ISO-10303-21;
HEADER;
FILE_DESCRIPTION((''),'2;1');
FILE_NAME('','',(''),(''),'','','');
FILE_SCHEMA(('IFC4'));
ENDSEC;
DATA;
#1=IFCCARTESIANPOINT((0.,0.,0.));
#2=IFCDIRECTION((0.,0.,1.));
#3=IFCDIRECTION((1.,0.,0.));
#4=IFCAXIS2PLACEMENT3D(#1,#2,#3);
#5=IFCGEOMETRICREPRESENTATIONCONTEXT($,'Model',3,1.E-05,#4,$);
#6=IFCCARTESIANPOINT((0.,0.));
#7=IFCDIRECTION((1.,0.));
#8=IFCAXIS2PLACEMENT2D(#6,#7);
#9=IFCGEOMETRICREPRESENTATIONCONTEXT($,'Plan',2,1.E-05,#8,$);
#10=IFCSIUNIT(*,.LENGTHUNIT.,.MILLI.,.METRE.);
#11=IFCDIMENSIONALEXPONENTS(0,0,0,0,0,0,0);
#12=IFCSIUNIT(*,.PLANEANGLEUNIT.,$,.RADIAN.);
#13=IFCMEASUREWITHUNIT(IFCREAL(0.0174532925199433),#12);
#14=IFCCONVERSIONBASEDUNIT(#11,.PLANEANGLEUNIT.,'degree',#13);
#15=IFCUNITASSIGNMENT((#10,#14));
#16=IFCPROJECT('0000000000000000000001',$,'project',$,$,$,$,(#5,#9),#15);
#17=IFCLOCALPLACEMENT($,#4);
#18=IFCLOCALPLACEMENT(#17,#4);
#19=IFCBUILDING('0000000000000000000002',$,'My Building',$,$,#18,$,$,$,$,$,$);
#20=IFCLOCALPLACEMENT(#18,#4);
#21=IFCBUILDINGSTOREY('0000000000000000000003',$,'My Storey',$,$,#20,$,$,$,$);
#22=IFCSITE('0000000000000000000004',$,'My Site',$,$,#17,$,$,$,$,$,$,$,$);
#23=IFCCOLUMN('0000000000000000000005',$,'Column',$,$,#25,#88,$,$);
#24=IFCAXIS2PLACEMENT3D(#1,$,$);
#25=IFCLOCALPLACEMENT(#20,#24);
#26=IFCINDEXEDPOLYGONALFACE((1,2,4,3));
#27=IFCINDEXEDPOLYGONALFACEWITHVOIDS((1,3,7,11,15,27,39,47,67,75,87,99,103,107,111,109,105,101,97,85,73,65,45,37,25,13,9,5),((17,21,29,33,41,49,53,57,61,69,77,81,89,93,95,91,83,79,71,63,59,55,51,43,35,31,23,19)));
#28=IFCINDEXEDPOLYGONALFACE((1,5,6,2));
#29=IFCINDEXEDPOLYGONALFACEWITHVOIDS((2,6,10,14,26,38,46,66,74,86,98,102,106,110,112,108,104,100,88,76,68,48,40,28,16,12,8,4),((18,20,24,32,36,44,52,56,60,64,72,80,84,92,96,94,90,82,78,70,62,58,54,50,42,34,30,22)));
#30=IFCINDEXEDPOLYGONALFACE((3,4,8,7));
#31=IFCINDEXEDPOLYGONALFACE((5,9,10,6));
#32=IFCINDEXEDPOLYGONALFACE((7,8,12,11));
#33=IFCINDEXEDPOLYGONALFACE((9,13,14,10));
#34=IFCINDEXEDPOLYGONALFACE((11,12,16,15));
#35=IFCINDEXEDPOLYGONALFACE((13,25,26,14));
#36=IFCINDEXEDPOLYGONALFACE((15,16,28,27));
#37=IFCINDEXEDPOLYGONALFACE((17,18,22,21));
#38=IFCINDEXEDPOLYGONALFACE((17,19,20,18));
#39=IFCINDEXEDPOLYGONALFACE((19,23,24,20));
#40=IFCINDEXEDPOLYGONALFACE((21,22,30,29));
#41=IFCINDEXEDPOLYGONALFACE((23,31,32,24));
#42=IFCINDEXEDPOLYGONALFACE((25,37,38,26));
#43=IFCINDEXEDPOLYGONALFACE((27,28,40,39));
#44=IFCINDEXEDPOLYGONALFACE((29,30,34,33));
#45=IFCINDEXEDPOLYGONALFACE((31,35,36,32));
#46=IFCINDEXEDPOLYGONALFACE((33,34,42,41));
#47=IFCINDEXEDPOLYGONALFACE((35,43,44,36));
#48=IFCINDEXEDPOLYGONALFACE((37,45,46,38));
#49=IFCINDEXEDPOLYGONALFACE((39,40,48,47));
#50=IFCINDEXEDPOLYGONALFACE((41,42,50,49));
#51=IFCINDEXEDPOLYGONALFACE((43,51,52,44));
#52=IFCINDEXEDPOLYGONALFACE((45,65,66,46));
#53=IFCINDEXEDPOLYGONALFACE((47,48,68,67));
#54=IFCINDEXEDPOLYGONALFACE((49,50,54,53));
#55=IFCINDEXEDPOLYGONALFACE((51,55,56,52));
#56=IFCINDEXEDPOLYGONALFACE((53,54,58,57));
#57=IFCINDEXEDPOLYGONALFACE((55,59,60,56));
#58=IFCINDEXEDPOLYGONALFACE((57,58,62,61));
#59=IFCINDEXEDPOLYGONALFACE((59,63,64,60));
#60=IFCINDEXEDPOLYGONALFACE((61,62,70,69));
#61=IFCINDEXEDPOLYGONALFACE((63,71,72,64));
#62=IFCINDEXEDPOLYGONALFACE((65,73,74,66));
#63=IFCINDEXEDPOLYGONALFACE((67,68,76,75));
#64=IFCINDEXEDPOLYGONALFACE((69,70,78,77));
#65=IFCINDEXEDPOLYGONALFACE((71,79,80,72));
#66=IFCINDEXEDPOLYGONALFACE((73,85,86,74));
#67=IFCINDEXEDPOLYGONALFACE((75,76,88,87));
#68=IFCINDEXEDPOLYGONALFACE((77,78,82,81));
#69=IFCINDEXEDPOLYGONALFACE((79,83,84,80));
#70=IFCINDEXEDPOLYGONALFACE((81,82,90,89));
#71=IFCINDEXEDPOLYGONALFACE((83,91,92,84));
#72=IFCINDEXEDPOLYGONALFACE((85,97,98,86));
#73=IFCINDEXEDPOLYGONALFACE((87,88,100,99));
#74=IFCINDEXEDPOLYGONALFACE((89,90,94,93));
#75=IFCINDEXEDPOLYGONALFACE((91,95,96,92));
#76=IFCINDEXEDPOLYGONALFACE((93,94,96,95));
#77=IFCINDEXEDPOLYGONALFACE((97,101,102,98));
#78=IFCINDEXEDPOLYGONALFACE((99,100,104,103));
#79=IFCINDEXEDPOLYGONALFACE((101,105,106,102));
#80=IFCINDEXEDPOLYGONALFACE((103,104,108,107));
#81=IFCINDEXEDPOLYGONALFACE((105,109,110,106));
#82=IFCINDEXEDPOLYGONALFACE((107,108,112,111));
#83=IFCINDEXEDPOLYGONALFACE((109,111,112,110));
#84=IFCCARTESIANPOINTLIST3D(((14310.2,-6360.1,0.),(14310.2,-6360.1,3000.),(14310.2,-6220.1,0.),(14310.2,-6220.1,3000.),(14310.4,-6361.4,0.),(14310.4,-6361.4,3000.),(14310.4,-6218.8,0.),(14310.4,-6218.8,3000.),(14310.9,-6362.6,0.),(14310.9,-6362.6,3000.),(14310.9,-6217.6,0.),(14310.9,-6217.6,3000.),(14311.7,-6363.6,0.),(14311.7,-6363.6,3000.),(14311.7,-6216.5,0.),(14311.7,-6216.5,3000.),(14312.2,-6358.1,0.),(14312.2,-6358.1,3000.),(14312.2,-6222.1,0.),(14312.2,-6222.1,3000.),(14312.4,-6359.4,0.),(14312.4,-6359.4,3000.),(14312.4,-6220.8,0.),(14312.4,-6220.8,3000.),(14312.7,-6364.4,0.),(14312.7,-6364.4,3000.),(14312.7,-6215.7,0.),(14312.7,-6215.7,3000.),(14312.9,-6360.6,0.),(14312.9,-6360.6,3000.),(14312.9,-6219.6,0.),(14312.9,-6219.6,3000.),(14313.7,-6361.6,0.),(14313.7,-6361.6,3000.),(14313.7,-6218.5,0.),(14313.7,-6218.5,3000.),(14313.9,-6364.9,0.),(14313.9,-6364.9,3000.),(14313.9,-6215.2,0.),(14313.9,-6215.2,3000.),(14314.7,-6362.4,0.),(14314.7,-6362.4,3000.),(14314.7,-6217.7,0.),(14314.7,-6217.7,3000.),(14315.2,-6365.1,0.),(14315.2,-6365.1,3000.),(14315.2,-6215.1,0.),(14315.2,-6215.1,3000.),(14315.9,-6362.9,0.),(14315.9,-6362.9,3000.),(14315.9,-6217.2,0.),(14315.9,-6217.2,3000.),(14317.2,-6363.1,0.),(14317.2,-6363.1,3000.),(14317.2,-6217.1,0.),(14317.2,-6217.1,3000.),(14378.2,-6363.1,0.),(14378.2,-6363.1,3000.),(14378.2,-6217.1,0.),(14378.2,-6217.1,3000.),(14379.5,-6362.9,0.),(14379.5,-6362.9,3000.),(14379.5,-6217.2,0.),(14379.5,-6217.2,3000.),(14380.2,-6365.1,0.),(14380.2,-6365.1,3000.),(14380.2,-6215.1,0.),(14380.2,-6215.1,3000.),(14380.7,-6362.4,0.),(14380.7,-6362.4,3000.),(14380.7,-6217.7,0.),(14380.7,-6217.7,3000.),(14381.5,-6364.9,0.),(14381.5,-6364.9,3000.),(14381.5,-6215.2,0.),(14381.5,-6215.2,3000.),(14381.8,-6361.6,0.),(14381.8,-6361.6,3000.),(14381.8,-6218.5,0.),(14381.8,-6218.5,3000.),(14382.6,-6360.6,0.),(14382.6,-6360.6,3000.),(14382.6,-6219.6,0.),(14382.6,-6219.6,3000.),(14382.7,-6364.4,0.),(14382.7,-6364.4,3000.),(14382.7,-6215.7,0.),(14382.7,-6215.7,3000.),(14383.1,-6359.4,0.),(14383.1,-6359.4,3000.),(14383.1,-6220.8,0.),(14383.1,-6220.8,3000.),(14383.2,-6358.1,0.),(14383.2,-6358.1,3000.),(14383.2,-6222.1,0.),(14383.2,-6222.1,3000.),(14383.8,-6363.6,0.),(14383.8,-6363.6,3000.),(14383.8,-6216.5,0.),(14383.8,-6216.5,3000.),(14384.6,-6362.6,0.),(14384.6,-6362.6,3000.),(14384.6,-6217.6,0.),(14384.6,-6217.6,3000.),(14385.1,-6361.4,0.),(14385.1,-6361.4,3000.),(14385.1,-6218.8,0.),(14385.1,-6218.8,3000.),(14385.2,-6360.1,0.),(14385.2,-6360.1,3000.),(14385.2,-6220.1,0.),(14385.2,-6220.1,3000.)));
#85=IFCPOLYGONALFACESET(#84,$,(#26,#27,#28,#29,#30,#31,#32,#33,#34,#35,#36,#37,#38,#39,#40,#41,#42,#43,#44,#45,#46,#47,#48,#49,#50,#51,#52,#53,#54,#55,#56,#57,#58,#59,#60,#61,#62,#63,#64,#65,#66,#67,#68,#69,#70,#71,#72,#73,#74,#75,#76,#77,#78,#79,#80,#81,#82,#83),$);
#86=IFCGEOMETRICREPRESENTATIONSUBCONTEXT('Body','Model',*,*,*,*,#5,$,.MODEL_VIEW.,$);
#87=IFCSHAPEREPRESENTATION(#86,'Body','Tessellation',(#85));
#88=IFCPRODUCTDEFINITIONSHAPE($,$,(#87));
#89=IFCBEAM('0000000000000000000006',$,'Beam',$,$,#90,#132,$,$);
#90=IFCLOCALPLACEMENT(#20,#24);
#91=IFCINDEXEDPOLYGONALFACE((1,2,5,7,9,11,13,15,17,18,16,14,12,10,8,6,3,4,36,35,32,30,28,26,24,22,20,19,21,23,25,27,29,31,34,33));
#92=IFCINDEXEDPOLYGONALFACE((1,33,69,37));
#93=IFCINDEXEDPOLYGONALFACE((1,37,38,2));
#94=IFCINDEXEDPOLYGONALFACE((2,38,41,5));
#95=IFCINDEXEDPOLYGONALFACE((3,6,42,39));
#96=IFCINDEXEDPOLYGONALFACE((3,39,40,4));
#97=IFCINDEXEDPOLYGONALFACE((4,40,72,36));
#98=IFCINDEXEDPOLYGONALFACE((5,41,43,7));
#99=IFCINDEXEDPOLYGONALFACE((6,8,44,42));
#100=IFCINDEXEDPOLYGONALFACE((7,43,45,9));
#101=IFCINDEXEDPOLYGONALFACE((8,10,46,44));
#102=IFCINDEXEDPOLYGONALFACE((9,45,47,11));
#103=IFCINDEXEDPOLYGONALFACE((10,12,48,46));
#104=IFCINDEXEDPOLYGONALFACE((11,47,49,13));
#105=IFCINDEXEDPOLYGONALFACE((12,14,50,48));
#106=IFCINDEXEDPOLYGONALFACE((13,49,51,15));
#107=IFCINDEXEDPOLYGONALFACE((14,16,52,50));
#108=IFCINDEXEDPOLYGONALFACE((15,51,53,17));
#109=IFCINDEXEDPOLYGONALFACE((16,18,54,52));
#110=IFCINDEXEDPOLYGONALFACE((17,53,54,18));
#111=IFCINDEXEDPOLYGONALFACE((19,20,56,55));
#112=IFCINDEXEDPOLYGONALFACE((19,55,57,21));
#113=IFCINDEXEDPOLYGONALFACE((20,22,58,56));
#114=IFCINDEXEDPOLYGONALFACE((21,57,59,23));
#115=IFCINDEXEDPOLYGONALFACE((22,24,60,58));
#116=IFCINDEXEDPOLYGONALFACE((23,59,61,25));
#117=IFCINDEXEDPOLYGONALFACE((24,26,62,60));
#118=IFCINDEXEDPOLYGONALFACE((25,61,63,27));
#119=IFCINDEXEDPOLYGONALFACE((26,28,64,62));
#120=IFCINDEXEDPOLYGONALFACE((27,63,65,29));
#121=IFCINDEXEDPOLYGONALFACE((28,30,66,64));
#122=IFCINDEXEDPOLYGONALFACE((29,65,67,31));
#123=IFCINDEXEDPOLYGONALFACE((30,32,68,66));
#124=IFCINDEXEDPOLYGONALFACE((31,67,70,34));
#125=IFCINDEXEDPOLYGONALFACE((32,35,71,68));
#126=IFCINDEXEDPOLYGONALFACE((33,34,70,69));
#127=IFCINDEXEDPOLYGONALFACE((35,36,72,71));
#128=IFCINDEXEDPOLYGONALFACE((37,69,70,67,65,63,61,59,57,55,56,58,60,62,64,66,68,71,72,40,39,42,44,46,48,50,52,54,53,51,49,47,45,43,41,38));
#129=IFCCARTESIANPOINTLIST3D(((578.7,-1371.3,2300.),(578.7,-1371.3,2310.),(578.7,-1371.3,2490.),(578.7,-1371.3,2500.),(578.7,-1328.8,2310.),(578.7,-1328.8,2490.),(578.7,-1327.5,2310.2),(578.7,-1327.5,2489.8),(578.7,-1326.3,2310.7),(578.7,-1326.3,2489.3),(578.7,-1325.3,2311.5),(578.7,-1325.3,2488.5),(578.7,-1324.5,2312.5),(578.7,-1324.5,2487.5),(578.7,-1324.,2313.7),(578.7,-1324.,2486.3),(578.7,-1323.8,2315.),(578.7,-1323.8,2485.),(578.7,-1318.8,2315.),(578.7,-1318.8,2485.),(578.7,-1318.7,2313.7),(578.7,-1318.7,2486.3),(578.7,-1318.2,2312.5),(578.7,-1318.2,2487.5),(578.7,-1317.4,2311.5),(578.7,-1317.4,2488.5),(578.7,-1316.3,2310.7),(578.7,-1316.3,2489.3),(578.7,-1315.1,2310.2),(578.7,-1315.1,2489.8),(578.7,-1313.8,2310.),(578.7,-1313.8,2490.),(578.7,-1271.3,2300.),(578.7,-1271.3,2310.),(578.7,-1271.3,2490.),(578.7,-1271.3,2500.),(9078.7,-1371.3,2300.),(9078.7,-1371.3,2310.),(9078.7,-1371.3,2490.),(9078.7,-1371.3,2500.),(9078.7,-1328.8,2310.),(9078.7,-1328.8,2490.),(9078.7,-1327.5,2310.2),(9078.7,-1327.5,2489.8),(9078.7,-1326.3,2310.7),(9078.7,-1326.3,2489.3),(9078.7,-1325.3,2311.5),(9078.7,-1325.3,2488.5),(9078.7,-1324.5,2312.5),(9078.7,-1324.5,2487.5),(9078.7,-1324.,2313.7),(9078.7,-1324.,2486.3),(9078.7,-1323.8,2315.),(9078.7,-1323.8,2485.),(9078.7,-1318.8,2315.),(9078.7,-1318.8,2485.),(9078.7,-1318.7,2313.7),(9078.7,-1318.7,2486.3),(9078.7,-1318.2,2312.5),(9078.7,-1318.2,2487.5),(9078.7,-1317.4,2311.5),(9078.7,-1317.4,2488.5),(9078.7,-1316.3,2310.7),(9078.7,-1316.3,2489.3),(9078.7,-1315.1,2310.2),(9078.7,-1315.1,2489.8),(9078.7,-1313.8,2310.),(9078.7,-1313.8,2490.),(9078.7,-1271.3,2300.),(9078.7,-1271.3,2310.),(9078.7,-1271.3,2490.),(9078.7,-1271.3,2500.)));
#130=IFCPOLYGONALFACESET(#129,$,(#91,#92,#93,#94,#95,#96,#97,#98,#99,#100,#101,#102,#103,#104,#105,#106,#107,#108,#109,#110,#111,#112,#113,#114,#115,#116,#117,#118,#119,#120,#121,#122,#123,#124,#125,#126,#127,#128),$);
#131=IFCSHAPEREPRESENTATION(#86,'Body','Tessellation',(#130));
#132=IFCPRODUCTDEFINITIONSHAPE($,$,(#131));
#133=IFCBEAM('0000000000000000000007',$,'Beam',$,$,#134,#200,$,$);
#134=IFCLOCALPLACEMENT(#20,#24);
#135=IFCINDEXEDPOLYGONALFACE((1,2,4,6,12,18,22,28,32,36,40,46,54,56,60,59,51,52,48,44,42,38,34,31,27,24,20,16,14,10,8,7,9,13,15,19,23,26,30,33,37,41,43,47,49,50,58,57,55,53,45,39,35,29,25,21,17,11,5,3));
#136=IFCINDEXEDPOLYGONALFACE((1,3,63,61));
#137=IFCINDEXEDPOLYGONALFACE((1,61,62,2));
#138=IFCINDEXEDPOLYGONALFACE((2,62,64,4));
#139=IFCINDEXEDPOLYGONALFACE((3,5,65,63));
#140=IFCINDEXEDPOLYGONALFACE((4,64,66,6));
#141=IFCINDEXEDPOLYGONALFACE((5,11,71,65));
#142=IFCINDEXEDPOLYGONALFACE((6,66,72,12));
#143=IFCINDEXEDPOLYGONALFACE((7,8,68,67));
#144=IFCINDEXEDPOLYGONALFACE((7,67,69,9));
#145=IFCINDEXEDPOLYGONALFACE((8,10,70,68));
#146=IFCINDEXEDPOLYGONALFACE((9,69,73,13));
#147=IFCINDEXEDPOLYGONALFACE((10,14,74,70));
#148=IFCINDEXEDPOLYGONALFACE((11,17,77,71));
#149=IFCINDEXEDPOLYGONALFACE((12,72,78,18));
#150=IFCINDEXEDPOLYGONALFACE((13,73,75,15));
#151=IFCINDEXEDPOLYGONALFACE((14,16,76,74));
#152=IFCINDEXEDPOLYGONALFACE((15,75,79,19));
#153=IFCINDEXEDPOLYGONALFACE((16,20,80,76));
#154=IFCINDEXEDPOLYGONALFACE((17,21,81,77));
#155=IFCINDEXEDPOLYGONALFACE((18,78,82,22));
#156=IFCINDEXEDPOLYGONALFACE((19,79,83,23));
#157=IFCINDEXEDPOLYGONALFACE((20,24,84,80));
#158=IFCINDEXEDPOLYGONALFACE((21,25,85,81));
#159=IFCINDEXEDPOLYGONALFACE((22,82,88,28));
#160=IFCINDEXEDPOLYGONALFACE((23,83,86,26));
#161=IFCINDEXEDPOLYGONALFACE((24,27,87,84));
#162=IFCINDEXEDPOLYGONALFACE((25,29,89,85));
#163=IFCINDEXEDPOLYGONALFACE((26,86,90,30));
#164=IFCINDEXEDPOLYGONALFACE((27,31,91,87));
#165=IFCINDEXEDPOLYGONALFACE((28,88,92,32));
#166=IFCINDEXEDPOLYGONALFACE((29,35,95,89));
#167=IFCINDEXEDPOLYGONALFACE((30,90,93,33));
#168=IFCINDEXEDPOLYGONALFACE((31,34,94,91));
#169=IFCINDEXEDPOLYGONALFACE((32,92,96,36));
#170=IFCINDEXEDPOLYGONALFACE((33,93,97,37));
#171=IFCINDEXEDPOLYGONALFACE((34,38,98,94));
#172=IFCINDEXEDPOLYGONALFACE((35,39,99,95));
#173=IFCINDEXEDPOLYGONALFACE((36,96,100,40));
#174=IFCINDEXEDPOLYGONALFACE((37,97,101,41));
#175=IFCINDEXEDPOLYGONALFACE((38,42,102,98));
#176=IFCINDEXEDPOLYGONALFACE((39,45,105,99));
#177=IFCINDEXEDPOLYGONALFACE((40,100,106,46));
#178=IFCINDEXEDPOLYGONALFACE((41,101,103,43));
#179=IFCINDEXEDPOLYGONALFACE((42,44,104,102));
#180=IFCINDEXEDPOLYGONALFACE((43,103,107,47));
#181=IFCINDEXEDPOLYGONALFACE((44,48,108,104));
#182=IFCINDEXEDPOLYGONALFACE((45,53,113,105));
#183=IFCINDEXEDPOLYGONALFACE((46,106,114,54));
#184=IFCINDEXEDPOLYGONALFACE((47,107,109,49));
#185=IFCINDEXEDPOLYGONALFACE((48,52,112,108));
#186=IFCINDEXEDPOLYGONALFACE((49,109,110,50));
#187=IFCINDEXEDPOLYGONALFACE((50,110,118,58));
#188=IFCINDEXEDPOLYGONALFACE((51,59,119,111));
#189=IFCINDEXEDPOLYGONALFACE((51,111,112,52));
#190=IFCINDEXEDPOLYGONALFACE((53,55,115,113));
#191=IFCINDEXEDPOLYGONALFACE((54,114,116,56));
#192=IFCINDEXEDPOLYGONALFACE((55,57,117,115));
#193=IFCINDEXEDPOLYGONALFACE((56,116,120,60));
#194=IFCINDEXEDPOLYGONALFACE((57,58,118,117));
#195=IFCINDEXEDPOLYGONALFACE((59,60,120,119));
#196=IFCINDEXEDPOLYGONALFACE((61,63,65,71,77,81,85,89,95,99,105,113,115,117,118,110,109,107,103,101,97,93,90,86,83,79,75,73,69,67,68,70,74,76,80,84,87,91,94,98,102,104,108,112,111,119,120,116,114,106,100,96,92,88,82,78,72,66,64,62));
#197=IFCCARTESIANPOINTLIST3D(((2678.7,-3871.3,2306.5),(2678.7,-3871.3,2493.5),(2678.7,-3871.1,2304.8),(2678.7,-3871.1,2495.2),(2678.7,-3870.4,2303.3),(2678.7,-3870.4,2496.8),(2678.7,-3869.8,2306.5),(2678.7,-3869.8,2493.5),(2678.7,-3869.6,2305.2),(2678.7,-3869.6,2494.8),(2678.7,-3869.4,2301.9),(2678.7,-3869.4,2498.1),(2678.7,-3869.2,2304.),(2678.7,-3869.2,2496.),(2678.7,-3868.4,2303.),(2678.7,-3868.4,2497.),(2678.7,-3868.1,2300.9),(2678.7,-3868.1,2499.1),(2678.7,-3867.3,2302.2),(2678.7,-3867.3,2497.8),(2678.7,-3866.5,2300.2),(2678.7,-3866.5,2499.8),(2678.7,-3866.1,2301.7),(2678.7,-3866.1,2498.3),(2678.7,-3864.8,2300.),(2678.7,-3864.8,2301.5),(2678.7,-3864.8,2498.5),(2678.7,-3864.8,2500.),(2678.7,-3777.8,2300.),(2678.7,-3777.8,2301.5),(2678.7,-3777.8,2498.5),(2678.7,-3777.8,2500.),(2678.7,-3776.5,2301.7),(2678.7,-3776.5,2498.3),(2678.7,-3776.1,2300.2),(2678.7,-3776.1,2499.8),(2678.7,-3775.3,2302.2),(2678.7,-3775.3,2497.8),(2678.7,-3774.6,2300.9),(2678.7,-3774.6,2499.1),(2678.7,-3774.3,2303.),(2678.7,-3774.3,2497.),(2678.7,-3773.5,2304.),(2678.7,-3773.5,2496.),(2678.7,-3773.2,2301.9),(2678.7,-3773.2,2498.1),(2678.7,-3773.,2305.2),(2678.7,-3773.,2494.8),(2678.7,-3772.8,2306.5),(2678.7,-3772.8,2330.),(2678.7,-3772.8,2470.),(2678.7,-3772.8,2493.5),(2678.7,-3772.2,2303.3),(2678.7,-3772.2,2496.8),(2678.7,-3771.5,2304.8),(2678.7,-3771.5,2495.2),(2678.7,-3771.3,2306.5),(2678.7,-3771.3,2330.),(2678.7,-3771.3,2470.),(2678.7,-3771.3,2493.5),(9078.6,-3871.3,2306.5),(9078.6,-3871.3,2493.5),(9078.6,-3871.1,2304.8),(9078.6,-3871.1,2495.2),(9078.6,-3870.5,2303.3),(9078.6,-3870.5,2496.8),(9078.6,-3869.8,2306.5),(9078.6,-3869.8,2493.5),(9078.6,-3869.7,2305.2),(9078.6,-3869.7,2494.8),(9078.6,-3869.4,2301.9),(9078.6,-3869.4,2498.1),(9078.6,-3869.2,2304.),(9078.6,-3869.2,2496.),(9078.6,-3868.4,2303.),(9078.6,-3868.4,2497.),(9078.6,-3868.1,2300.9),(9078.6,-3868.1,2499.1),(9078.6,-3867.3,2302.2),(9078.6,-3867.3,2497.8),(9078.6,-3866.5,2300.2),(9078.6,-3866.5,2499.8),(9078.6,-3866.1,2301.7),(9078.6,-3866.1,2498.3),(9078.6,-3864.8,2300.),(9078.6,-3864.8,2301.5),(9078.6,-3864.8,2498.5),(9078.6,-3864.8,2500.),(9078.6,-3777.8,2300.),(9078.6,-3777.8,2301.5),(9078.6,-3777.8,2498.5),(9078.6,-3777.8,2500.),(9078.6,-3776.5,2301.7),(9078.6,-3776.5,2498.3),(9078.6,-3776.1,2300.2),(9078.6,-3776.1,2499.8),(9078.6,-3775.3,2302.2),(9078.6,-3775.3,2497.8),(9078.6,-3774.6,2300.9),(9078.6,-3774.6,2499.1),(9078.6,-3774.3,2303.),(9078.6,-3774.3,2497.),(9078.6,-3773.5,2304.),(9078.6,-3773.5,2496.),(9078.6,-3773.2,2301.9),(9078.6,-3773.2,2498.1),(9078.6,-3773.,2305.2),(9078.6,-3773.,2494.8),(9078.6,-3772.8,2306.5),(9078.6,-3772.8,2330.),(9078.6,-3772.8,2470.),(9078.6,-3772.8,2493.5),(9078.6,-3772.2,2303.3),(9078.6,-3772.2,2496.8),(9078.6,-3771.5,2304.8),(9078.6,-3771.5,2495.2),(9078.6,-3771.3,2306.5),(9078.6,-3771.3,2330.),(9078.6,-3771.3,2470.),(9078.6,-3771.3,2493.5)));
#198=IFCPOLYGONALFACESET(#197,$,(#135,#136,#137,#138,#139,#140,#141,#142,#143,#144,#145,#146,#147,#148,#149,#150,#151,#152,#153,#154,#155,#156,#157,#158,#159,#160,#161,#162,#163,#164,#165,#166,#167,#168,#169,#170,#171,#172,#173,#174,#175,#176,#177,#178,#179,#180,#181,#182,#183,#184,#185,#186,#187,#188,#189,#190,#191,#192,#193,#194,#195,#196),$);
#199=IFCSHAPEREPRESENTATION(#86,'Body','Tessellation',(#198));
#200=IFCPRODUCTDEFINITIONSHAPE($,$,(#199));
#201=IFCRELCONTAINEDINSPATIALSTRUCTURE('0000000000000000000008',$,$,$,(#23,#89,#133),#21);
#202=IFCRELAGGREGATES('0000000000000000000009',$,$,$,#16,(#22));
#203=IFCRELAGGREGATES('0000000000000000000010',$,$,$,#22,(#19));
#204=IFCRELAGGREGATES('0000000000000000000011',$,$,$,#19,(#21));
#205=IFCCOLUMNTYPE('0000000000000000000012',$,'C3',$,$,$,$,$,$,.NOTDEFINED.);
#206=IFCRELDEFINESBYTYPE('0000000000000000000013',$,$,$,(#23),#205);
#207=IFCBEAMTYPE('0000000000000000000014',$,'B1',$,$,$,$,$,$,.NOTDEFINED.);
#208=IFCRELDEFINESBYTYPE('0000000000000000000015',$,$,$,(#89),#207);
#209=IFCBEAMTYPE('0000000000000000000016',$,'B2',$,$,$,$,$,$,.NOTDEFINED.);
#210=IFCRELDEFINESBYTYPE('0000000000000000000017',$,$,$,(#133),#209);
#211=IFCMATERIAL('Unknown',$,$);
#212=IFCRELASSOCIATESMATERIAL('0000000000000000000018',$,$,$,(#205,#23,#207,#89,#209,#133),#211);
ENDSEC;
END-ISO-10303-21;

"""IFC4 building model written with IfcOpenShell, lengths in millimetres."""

from ifc_helpers import new_model, entity, si_unit, converted_unit, frame, origin_with_axes, origin_2d_with_axis, place, context, subcontext, project, spatial, hollow_rectangle, i_section, c_section, extrude, material, material_profile, profile_set, profile_usage, type_object, element, save


model = new_model("IFC4")

# Units and contexts
model_context = context("Model", 3, precision=1e-05, world=origin_with_axes())
plan_context = context("Plan", 2, precision=1e-05, world=origin_2d_with_axis())
body_context_1 = subcontext(model_context, "Body", "Model", "MODEL_VIEW")
ifc_project = project(units=[si_unit("LENGTHUNIT", "METRE", prefix="MILLI"), converted_unit("PLANEANGLEUNIT", "degree", entity("IfcReal", 0.0174532925199433), si_unit("PLANEANGLEUNIT", "RADIAN"), dimensions=[0, 0, 0, 0, 0, 0, 0])], contexts=[model_context, plan_context])

# Site, building, storey
site_placement = place(None, origin_with_axes())
site = spatial("IfcSite", under=ifc_project, at=site_placement, Name="My Site")
building_placement = place(site_placement, origin_with_axes())
building = spatial("IfcBuilding", under=site, at=building_placement, Name="My Building")
storey_placement = place(building_placement, origin_with_axes())
storey = spatial("IfcBuildingStorey", under=building, at=storey_placement, Name="My Storey")

# Column
ifc_material = material(Name="Unknown")
ifc_material_profile_1 = material_profile(ifc_material, hollow_rectangle(XDim=75.0, YDim=150.0, WallThickness=2.0, InnerFilletRadius=5.0, OuterFilletRadius=5.0))
ifc_profile_set_1 = profile_set([ifc_material_profile_1])
column_type_1 = type_object("IfcColumnType", Name="C3", PredefinedType="NOTDEFINED", material=ifc_profile_set_1)
ifc_profile_usage_1 = profile_usage(ifc_profile_set_1)
column_1_placement = place(storey_placement, frame((14347.7, -6290.1, 0.0), z_axis=(0.0, 0.0, 1.0), x_axis=(1.0, 0.0, 0.0)))
element("IfcColumn", 1, at=column_1_placement, inside=storey, type_object=column_type_1, material=ifc_profile_usage_1, Name="Column", context=body_context_1, shape_type="SweptSolid", body=[
    extrude(hollow_rectangle(XDim=75.0, YDim=150.0, WallThickness=2.0, InnerFilletRadius=5.0, OuterFilletRadius=5.0), origin_with_axes(), (0.0, 0.0, 1.0), 3000.0),
])

# Beams
ifc_material_profile_2 = material_profile(ifc_material, i_section(OverallWidth=100.0, OverallDepth=200.0, WebThickness=5.0, FlangeThickness=10.0, FilletRadius=5.0))
ifc_profile_set_2 = profile_set([ifc_material_profile_2])
ifc_profile_usage_2 = profile_usage(ifc_profile_set_2, cardinal=5)
beam_type_1 = type_object("IfcBeamType", Name="B1", PredefinedType="NOTDEFINED", material=ifc_profile_set_2)
beam_1_placement = place(storey_placement, frame((9078.7, -1321.3, 2400.0), z_axis=(-1.0, 0.0, 0.0), x_axis=(0.0, -1.0, 0.0)))
element("IfcBeam", 2, at=beam_1_placement, inside=storey, type_object=beam_type_1, material=ifc_profile_usage_2, Name="Beam", context=body_context_1, shape_type="SweptSolid", body=[
    extrude(i_section(OverallWidth=100.0, OverallDepth=200.0, WebThickness=5.0, FlangeThickness=10.0, FilletRadius=5.0), origin_with_axes(), (0.0, 0.0, 1.0), 8500.0),
])
ifc_material_profile_3 = material_profile(ifc_material, c_section(Depth=200.0, Width=100.0, WallThickness=1.5, Girth=30.0, InternalFilletRadius=5.0))
ifc_profile_set_3 = profile_set([ifc_material_profile_3])
ifc_profile_usage_3 = profile_usage(ifc_profile_set_3, cardinal=5)
beam_type_2 = type_object("IfcBeamType", Name="B2", PredefinedType="NOTDEFINED", material=ifc_profile_set_3)
beam_2_placement = place(storey_placement, frame((2678.7, -3821.3, 2400.0), z_axis=(1.0, -0.000001, 0.000001), x_axis=(0.000001, 1.0, 0.0)))
element("IfcBeam", 3, at=beam_2_placement, inside=storey, type_object=beam_type_2, material=ifc_profile_usage_3, Name="Beam", context=body_context_1, shape_type="SweptSolid", body=[
    extrude(c_section(Depth=200.0, Width=100.0, WallThickness=1.5, Girth=30.0, InternalFilletRadius=5.0), origin_with_axes(), (0.0, 0.0, 1.0), 6399.9),
])

save(model, "model.ifc")
